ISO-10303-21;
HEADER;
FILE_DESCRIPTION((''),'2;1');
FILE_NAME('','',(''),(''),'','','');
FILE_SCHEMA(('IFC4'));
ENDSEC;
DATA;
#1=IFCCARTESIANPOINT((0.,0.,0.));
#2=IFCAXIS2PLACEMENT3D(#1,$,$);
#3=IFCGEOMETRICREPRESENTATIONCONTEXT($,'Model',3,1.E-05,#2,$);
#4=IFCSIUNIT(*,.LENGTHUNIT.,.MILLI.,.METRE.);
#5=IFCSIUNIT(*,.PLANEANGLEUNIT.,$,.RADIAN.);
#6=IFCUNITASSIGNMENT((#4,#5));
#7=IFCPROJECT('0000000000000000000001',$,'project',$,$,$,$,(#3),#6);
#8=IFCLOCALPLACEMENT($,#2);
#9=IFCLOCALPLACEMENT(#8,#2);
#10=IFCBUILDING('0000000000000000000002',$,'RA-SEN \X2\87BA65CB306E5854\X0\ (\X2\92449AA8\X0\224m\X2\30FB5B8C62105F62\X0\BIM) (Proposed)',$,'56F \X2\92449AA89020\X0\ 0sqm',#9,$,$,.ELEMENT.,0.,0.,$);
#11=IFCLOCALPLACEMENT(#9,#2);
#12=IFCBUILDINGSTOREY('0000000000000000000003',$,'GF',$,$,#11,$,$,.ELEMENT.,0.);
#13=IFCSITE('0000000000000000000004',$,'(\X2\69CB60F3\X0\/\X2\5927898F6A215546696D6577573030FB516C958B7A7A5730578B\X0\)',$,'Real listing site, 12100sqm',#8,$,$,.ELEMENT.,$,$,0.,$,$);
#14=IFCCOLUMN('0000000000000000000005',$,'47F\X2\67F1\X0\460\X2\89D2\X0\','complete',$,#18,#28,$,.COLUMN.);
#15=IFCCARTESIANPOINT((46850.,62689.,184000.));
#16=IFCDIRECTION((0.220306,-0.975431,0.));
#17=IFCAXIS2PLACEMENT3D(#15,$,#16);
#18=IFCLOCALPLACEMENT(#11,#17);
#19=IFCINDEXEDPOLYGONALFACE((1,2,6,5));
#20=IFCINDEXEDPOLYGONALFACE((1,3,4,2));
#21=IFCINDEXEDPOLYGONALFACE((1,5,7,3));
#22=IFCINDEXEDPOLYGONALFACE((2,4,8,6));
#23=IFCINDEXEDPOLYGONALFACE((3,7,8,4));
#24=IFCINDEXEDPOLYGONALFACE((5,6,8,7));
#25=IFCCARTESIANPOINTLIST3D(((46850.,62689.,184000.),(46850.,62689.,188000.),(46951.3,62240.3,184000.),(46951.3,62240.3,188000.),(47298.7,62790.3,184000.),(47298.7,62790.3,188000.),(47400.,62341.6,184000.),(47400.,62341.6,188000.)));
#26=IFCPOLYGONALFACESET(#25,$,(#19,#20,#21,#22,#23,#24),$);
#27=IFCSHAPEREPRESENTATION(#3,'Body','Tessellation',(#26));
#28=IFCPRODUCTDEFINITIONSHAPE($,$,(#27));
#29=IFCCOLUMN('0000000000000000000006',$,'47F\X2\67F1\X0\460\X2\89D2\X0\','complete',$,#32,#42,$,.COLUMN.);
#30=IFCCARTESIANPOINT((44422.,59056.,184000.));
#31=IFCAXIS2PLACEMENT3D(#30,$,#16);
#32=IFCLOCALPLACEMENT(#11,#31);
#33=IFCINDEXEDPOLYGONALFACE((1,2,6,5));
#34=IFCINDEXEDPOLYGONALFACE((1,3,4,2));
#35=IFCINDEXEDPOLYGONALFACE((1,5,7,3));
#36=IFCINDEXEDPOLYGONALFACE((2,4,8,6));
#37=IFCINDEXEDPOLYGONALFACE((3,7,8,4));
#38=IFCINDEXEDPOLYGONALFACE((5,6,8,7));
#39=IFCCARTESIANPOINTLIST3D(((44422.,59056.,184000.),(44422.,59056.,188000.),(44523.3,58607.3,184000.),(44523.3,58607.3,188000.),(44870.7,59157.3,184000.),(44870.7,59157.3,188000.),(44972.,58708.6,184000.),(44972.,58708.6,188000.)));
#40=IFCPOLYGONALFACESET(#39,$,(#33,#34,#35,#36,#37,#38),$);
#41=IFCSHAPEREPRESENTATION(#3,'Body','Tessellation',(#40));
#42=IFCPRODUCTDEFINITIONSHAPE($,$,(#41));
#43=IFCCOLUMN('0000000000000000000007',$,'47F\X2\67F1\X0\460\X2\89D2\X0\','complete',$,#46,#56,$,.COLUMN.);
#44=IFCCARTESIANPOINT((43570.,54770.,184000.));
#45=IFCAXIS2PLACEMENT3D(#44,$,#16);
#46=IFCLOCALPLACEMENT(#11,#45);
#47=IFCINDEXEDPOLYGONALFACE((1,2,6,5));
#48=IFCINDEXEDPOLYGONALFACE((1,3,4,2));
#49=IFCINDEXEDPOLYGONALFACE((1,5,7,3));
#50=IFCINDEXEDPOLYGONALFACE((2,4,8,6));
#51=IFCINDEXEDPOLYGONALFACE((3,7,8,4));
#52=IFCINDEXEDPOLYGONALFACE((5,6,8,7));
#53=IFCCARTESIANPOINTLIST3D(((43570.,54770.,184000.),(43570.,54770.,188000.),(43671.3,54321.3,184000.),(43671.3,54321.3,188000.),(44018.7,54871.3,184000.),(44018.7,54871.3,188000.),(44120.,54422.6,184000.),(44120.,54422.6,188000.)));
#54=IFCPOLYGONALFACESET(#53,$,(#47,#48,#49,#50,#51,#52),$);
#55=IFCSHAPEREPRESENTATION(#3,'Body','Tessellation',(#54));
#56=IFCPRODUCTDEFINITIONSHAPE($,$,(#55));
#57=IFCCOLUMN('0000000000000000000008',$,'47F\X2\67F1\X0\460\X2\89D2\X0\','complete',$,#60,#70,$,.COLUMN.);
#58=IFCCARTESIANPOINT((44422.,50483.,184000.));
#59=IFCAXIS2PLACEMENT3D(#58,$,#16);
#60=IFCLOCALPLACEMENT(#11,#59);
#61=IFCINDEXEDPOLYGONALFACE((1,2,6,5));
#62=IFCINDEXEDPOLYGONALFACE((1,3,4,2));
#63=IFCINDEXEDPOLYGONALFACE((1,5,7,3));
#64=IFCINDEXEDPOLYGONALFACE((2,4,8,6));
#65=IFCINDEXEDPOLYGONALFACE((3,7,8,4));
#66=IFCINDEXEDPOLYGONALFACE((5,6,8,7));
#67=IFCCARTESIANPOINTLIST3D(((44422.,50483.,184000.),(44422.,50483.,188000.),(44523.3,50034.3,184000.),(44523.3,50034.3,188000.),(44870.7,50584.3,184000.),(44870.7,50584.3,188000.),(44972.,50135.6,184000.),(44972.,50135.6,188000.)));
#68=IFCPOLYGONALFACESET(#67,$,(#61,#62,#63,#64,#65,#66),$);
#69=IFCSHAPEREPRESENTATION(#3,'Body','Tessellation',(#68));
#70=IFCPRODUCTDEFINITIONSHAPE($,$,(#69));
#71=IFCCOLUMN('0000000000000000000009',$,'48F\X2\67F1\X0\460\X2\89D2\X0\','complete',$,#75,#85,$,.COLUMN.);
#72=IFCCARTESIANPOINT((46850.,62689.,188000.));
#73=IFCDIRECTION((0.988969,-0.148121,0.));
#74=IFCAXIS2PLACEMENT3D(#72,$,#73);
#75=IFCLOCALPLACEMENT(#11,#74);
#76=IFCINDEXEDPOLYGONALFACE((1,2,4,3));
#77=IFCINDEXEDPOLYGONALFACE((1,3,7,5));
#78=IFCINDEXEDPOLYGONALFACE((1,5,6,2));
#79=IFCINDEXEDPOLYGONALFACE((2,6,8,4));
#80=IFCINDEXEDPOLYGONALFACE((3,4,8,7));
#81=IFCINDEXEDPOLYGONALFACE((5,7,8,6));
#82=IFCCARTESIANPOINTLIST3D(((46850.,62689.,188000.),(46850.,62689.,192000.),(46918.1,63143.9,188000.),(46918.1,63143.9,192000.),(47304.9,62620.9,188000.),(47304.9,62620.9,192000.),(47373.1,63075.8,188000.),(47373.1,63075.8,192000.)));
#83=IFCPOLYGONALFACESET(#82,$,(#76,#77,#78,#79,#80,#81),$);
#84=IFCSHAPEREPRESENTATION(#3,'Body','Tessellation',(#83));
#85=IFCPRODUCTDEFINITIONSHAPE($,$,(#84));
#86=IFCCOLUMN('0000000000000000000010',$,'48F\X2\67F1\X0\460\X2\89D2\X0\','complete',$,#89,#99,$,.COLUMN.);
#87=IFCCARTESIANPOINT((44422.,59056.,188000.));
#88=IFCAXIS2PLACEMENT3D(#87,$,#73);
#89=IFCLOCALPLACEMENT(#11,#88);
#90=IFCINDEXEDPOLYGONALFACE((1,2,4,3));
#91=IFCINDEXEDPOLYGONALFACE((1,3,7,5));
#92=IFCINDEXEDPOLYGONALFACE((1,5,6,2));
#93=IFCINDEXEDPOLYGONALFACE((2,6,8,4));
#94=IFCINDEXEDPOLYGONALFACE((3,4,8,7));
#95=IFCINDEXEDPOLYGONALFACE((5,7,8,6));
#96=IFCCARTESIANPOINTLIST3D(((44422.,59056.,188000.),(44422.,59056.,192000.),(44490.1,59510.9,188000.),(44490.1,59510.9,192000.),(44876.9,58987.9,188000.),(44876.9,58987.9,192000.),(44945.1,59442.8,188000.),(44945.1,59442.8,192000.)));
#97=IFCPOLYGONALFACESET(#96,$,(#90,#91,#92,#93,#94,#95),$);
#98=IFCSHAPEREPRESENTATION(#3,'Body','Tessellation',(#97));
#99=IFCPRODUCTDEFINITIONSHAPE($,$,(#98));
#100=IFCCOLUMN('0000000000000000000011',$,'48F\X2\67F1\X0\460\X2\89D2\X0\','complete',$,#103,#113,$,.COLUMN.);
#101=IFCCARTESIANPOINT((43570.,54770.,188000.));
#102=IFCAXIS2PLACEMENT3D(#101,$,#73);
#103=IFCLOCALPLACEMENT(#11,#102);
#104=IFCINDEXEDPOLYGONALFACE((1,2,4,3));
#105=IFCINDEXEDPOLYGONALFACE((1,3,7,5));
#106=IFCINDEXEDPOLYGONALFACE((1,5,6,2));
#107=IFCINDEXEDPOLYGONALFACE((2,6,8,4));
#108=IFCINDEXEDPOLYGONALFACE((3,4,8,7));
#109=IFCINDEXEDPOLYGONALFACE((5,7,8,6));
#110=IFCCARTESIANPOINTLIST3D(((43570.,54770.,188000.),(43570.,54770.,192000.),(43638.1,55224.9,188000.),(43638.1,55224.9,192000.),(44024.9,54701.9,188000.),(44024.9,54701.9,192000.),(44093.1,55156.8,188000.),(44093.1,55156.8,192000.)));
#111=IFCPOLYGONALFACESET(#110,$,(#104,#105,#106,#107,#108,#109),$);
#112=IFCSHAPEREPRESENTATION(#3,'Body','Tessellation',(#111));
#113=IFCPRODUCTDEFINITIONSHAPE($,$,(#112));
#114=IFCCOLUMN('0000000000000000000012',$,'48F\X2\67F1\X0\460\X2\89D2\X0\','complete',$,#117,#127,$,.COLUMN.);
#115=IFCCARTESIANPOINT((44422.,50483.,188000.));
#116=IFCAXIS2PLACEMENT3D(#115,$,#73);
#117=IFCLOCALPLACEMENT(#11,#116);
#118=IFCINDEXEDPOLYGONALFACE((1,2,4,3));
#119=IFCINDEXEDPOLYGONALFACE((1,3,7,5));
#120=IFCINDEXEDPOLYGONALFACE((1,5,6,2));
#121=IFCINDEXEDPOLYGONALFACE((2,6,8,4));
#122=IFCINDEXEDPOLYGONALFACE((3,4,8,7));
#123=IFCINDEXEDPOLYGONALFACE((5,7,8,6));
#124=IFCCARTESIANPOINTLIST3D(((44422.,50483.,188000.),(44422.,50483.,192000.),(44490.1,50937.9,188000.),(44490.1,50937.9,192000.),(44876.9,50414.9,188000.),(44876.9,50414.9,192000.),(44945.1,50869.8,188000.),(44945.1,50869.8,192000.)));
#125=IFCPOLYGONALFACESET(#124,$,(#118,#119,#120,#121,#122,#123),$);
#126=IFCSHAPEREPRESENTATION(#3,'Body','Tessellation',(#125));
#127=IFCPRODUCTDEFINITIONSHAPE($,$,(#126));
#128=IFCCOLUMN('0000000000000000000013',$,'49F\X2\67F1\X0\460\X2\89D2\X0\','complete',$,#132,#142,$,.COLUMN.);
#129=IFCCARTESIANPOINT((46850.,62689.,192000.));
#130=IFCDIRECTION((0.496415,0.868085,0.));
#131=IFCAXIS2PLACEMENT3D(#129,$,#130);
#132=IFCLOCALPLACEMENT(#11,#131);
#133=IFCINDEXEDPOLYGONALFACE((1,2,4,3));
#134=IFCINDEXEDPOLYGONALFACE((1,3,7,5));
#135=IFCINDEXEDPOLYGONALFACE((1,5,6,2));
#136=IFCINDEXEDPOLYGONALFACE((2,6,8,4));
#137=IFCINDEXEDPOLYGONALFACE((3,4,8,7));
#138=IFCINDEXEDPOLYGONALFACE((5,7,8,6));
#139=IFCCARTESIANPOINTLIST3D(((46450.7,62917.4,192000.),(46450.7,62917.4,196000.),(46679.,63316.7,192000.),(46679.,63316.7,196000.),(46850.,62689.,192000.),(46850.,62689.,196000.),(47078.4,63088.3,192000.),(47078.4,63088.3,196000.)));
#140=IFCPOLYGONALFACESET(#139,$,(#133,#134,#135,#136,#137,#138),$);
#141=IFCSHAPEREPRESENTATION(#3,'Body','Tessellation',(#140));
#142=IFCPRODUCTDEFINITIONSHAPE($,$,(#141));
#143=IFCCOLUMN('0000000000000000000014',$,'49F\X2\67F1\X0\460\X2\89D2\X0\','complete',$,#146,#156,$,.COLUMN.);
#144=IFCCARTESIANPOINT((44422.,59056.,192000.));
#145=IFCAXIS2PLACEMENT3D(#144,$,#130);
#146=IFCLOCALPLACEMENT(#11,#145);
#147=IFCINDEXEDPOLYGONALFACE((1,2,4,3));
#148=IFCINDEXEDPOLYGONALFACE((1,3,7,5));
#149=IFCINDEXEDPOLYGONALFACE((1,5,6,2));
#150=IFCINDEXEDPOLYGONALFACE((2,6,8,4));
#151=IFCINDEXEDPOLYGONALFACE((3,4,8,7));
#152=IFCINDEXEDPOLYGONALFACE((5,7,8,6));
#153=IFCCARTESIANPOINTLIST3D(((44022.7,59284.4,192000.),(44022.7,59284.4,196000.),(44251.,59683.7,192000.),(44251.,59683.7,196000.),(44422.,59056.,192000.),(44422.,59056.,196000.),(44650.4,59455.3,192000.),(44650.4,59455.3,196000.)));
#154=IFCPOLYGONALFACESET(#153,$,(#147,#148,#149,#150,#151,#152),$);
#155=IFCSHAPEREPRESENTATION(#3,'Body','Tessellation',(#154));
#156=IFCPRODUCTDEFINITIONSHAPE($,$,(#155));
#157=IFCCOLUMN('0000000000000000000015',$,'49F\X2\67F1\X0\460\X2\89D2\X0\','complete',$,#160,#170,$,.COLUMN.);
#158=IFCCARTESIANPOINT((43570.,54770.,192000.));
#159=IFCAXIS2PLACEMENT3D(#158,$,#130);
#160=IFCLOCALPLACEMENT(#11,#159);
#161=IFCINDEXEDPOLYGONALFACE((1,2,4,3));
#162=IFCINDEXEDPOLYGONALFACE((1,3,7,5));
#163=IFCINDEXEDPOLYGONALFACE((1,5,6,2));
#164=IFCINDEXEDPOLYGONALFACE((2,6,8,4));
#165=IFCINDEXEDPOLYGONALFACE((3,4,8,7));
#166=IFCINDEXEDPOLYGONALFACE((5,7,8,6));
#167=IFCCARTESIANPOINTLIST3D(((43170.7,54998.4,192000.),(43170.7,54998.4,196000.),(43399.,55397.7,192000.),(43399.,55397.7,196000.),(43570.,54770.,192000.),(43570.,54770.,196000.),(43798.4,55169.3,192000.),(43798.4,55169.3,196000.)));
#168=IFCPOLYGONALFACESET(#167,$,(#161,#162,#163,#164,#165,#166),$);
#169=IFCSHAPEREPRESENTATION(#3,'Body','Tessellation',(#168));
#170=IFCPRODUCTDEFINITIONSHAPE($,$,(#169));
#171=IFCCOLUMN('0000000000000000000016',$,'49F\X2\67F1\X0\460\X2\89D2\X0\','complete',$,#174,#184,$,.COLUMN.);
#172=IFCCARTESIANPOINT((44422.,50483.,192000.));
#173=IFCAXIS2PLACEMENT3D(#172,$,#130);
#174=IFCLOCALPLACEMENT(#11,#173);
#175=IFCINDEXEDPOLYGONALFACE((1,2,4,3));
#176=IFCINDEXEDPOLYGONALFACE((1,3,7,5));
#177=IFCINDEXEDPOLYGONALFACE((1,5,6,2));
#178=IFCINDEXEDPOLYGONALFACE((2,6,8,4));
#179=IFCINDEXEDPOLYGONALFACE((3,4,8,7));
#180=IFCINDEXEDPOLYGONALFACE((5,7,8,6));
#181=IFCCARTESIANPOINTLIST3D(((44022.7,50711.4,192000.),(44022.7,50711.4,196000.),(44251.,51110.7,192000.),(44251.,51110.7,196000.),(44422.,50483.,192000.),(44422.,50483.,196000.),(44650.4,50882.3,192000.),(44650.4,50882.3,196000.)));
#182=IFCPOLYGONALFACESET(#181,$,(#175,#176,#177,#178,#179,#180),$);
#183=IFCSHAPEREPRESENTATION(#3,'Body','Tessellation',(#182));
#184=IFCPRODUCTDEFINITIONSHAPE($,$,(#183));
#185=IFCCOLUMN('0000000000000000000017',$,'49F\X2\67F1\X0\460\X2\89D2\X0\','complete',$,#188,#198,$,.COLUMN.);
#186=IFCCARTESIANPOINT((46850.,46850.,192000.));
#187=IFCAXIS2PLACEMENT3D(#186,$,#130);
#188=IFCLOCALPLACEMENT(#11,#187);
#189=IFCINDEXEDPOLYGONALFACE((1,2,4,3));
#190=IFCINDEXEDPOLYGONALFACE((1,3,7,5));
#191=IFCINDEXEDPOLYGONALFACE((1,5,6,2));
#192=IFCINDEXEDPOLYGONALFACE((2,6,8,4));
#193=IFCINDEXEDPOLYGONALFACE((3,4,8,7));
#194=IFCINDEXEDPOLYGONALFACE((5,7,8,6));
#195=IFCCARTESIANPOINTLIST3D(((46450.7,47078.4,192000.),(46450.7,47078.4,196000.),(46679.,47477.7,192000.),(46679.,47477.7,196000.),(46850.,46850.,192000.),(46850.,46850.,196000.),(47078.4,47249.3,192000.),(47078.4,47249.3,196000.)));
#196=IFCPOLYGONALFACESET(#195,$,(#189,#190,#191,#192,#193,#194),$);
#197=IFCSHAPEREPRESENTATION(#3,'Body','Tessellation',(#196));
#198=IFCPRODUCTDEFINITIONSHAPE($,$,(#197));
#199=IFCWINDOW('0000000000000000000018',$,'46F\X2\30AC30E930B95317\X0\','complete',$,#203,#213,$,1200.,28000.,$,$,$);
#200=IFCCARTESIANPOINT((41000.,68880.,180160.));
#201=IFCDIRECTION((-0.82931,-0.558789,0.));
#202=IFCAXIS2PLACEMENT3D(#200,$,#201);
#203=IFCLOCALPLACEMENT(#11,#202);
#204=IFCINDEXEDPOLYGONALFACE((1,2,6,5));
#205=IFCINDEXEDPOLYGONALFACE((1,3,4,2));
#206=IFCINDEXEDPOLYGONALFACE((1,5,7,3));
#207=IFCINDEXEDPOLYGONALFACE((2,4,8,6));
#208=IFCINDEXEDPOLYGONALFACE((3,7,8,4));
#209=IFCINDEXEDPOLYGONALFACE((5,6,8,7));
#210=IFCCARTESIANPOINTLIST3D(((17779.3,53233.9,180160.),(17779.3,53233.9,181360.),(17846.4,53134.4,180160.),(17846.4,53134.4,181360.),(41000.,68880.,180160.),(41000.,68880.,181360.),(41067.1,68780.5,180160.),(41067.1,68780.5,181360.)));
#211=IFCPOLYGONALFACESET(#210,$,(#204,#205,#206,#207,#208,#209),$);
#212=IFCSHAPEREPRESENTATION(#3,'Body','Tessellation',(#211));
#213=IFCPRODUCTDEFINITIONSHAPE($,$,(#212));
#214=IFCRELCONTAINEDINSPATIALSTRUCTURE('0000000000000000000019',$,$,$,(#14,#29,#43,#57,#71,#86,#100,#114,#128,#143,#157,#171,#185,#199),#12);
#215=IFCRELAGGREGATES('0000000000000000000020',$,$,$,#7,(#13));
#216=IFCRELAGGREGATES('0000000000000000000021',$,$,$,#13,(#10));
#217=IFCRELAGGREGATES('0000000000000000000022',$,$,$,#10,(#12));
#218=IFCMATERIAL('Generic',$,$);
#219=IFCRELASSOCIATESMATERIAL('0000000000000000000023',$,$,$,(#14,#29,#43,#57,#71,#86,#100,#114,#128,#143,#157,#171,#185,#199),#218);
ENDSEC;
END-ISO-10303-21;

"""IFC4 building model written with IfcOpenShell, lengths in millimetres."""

from ifc_helpers import new_model, si_unit, frame, frame_2d, origin, place, context, project, spatial, rectangle, extrude, material, element, save


model = new_model("IFC4")

# Units and contexts
model_context = context("Model", 3, precision=1e-05, world=origin())
ifc_project = project(units=[si_unit("LENGTHUNIT", "METRE", prefix="MILLI"), si_unit("PLANEANGLEUNIT", "RADIAN")], contexts=[model_context])

# Site, building, storey
site_placement = place(None, origin())
site = spatial("IfcSite", under=ifc_project, at=site_placement, Name="(構想/大規模商業敷地・公開空地型)", ObjectType="Real listing site, 12100sqm", CompositionType="ELEMENT", RefElevation=0.0)
building_placement = place(site_placement, origin())
building = spatial("IfcBuilding", under=site, at=building_placement, Name="RA-SEN 螺旋の塔 (鉄骨224m・完成形BIM) (Proposed)", ObjectType="56F 鉄骨造 0sqm", CompositionType="ELEMENT", ElevationOfRefHeight=0.0, ElevationOfTerrain=0.0)
storey_placement = place(building_placement, origin())
storey = spatial("IfcBuildingStorey", under=building, at=storey_placement, Name="GF", CompositionType="ELEMENT", Elevation=0.0)

# Columns
ifc_material = material(Name="Generic")
column_1_placement = place(storey_placement, frame((46850.0, 62689.0, 184000.0), x_axis=(0.220306, -0.975431, 0.0)))
element("IfcColumn", 1, at=column_1_placement, inside=storey, material=ifc_material, Name="47F柱460角", Description="complete", PredefinedType="COLUMN", context=model_context, shape_type="SweptSolid", body=[
    extrude(rectangle(XDim=460.0, YDim=460.0, at=frame_2d((230.0, 230.0))), frame((46850.0, 62689.0, 184000.0), x_axis=(0.220306, -0.975431, 0.0)), (0.0, 0.0, 1.0), 4000.0),
])
column_2_placement = place(storey_placement, frame((44422.0, 59056.0, 184000.0), x_axis=(0.220306, -0.975431, 0.0)))
element("IfcColumn", 2, at=column_2_placement, inside=storey, material=ifc_material, Name="47F柱460角", Description="complete", PredefinedType="COLUMN", context=model_context, shape_type="SweptSolid", body=[
    extrude(rectangle(XDim=460.0, YDim=460.0, at=frame_2d((230.0, 230.0))), frame((44422.0, 59056.0, 184000.0), x_axis=(0.220306, -0.975431, 0.0)), (0.0, 0.0, 1.0), 4000.0),
])
column_3_placement = place(storey_placement, frame((43570.0, 54770.0, 184000.0), x_axis=(0.220306, -0.975431, 0.0)))
element("IfcColumn", 3, at=column_3_placement, inside=storey, material=ifc_material, Name="47F柱460角", Description="complete", PredefinedType="COLUMN", context=model_context, shape_type="SweptSolid", body=[
    extrude(rectangle(XDim=460.0, YDim=460.0, at=frame_2d((230.0, 230.0))), frame((43570.0, 54770.0, 184000.0), x_axis=(0.220306, -0.975431, 0.0)), (0.0, 0.0, 1.0), 4000.0),
])
column_4_placement = place(storey_placement, frame((44422.0, 50483.0, 184000.0), x_axis=(0.220306, -0.975431, 0.0)))
element("IfcColumn", 4, at=column_4_placement, inside=storey, material=ifc_material, Name="47F柱460角", Description="complete", PredefinedType="COLUMN", context=model_context, shape_type="SweptSolid", body=[
    extrude(rectangle(XDim=460.0, YDim=460.0, at=frame_2d((230.0, 230.0))), frame((44422.0, 50483.0, 184000.0), x_axis=(0.220306, -0.975431, 0.0)), (0.0, 0.0, 1.0), 4000.0),
])
column_5_placement = place(storey_placement, frame((46850.0, 62689.0, 188000.0), x_axis=(0.988969, -0.148121, 0.0)))
element("IfcColumn", 5, at=column_5_placement, inside=storey, material=ifc_material, Name="48F柱460角", Description="complete", PredefinedType="COLUMN", context=model_context, shape_type="SweptSolid", body=[
    extrude(rectangle(XDim=460.0, YDim=460.0, at=frame_2d((230.0, 230.0))), frame((46850.0, 62689.0, 188000.0), x_axis=(0.988969, -0.148121, 0.0)), (0.0, 0.0, 1.0), 4000.0),
])
column_6_placement = place(storey_placement, frame((44422.0, 59056.0, 188000.0), x_axis=(0.988969, -0.148121, 0.0)))
element("IfcColumn", 6, at=column_6_placement, inside=storey, material=ifc_material, Name="48F柱460角", Description="complete", PredefinedType="COLUMN", context=model_context, shape_type="SweptSolid", body=[
    extrude(rectangle(XDim=460.0, YDim=460.0, at=frame_2d((230.0, 230.0))), frame((44422.0, 59056.0, 188000.0), x_axis=(0.988969, -0.148121, 0.0)), (0.0, 0.0, 1.0), 4000.0),
])
column_7_placement = place(storey_placement, frame((43570.0, 54770.0, 188000.0), x_axis=(0.988969, -0.148121, 0.0)))
element("IfcColumn", 7, at=column_7_placement, inside=storey, material=ifc_material, Name="48F柱460角", Description="complete", PredefinedType="COLUMN", context=model_context, shape_type="SweptSolid", body=[
    extrude(rectangle(XDim=460.0, YDim=460.0, at=frame_2d((230.0, 230.0))), frame((43570.0, 54770.0, 188000.0), x_axis=(0.988969, -0.148121, 0.0)), (0.0, 0.0, 1.0), 4000.0),
])
column_8_placement = place(storey_placement, frame((44422.0, 50483.0, 188000.0), x_axis=(0.988969, -0.148121, 0.0)))
element("IfcColumn", 8, at=column_8_placement, inside=storey, material=ifc_material, Name="48F柱460角", Description="complete", PredefinedType="COLUMN", context=model_context, shape_type="SweptSolid", body=[
    extrude(rectangle(XDim=460.0, YDim=460.0, at=frame_2d((230.0, 230.0))), frame((44422.0, 50483.0, 188000.0), x_axis=(0.988969, -0.148121, 0.0)), (0.0, 0.0, 1.0), 4000.0),
])
column_9_placement = place(storey_placement, frame((46850.0, 62689.0, 192000.0), x_axis=(0.496415, 0.868085, 0.0)))
element("IfcColumn", 9, at=column_9_placement, inside=storey, material=ifc_material, Name="49F柱460角", Description="complete", PredefinedType="COLUMN", context=model_context, shape_type="SweptSolid", body=[
    extrude(rectangle(XDim=460.0, YDim=460.0, at=frame_2d((230.0, 230.0))), frame((46850.0, 62689.0, 192000.0), x_axis=(0.496415, 0.868085, 0.0)), (0.0, 0.0, 1.0), 4000.0),
])
column_10_placement = place(storey_placement, frame((44422.0, 59056.0, 192000.0), x_axis=(0.496415, 0.868085, 0.0)))
element("IfcColumn", 10, at=column_10_placement, inside=storey, material=ifc_material, Name="49F柱460角", Description="complete", PredefinedType="COLUMN", context=model_context, shape_type="SweptSolid", body=[
    extrude(rectangle(XDim=460.0, YDim=460.0, at=frame_2d((230.0, 230.0))), frame((44422.0, 59056.0, 192000.0), x_axis=(0.496415, 0.868085, 0.0)), (0.0, 0.0, 1.0), 4000.0),
])
column_11_placement = place(storey_placement, frame((43570.0, 54770.0, 192000.0), x_axis=(0.496415, 0.868085, 0.0)))
element("IfcColumn", 11, at=column_11_placement, inside=storey, material=ifc_material, Name="49F柱460角", Description="complete", PredefinedType="COLUMN", context=model_context, shape_type="SweptSolid", body=[
    extrude(rectangle(XDim=460.0, YDim=460.0, at=frame_2d((230.0, 230.0))), frame((43570.0, 54770.0, 192000.0), x_axis=(0.496415, 0.868085, 0.0)), (0.0, 0.0, 1.0), 4000.0),
])
column_12_placement = place(storey_placement, frame((44422.0, 50483.0, 192000.0), x_axis=(0.496415, 0.868085, 0.0)))
element("IfcColumn", 12, at=column_12_placement, inside=storey, material=ifc_material, Name="49F柱460角", Description="complete", PredefinedType="COLUMN", context=model_context, shape_type="SweptSolid", body=[
    extrude(rectangle(XDim=460.0, YDim=460.0, at=frame_2d((230.0, 230.0))), frame((44422.0, 50483.0, 192000.0), x_axis=(0.496415, 0.868085, 0.0)), (0.0, 0.0, 1.0), 4000.0),
])
column_13_placement = place(storey_placement, frame((46850.0, 46850.0, 192000.0), x_axis=(0.496415, 0.868085, 0.0)))
element("IfcColumn", 13, at=column_13_placement, inside=storey, material=ifc_material, Name="49F柱460角", Description="complete", PredefinedType="COLUMN", context=model_context, shape_type="SweptSolid", body=[
    extrude(rectangle(XDim=460.0, YDim=460.0, at=frame_2d((230.0, 230.0))), frame((46850.0, 46850.0, 192000.0), x_axis=(0.496415, 0.868085, 0.0)), (0.0, 0.0, 1.0), 4000.0),
])

# Window
window_1_placement = place(storey_placement, frame((41000.0, 68880.0, 180160.0), x_axis=(-0.82931, -0.558789, 0.0)))
element("IfcWindow", 14, at=window_1_placement, inside=storey, material=ifc_material, Name="46Fガラス北", Description="complete", OverallHeight=1200.0, OverallWidth=28000.0, context=model_context, shape_type="SweptSolid", body=[
    extrude(rectangle(XDim=28000.0, YDim=120.0, at=frame_2d((14000.0, 60.0))), frame((41000.0, 68880.0, 180160.0), x_axis=(-0.82931, -0.558789, 0.0)), (0.0, 0.0, 1.0), 1200.0),
])

save(model, "model.ifc")
